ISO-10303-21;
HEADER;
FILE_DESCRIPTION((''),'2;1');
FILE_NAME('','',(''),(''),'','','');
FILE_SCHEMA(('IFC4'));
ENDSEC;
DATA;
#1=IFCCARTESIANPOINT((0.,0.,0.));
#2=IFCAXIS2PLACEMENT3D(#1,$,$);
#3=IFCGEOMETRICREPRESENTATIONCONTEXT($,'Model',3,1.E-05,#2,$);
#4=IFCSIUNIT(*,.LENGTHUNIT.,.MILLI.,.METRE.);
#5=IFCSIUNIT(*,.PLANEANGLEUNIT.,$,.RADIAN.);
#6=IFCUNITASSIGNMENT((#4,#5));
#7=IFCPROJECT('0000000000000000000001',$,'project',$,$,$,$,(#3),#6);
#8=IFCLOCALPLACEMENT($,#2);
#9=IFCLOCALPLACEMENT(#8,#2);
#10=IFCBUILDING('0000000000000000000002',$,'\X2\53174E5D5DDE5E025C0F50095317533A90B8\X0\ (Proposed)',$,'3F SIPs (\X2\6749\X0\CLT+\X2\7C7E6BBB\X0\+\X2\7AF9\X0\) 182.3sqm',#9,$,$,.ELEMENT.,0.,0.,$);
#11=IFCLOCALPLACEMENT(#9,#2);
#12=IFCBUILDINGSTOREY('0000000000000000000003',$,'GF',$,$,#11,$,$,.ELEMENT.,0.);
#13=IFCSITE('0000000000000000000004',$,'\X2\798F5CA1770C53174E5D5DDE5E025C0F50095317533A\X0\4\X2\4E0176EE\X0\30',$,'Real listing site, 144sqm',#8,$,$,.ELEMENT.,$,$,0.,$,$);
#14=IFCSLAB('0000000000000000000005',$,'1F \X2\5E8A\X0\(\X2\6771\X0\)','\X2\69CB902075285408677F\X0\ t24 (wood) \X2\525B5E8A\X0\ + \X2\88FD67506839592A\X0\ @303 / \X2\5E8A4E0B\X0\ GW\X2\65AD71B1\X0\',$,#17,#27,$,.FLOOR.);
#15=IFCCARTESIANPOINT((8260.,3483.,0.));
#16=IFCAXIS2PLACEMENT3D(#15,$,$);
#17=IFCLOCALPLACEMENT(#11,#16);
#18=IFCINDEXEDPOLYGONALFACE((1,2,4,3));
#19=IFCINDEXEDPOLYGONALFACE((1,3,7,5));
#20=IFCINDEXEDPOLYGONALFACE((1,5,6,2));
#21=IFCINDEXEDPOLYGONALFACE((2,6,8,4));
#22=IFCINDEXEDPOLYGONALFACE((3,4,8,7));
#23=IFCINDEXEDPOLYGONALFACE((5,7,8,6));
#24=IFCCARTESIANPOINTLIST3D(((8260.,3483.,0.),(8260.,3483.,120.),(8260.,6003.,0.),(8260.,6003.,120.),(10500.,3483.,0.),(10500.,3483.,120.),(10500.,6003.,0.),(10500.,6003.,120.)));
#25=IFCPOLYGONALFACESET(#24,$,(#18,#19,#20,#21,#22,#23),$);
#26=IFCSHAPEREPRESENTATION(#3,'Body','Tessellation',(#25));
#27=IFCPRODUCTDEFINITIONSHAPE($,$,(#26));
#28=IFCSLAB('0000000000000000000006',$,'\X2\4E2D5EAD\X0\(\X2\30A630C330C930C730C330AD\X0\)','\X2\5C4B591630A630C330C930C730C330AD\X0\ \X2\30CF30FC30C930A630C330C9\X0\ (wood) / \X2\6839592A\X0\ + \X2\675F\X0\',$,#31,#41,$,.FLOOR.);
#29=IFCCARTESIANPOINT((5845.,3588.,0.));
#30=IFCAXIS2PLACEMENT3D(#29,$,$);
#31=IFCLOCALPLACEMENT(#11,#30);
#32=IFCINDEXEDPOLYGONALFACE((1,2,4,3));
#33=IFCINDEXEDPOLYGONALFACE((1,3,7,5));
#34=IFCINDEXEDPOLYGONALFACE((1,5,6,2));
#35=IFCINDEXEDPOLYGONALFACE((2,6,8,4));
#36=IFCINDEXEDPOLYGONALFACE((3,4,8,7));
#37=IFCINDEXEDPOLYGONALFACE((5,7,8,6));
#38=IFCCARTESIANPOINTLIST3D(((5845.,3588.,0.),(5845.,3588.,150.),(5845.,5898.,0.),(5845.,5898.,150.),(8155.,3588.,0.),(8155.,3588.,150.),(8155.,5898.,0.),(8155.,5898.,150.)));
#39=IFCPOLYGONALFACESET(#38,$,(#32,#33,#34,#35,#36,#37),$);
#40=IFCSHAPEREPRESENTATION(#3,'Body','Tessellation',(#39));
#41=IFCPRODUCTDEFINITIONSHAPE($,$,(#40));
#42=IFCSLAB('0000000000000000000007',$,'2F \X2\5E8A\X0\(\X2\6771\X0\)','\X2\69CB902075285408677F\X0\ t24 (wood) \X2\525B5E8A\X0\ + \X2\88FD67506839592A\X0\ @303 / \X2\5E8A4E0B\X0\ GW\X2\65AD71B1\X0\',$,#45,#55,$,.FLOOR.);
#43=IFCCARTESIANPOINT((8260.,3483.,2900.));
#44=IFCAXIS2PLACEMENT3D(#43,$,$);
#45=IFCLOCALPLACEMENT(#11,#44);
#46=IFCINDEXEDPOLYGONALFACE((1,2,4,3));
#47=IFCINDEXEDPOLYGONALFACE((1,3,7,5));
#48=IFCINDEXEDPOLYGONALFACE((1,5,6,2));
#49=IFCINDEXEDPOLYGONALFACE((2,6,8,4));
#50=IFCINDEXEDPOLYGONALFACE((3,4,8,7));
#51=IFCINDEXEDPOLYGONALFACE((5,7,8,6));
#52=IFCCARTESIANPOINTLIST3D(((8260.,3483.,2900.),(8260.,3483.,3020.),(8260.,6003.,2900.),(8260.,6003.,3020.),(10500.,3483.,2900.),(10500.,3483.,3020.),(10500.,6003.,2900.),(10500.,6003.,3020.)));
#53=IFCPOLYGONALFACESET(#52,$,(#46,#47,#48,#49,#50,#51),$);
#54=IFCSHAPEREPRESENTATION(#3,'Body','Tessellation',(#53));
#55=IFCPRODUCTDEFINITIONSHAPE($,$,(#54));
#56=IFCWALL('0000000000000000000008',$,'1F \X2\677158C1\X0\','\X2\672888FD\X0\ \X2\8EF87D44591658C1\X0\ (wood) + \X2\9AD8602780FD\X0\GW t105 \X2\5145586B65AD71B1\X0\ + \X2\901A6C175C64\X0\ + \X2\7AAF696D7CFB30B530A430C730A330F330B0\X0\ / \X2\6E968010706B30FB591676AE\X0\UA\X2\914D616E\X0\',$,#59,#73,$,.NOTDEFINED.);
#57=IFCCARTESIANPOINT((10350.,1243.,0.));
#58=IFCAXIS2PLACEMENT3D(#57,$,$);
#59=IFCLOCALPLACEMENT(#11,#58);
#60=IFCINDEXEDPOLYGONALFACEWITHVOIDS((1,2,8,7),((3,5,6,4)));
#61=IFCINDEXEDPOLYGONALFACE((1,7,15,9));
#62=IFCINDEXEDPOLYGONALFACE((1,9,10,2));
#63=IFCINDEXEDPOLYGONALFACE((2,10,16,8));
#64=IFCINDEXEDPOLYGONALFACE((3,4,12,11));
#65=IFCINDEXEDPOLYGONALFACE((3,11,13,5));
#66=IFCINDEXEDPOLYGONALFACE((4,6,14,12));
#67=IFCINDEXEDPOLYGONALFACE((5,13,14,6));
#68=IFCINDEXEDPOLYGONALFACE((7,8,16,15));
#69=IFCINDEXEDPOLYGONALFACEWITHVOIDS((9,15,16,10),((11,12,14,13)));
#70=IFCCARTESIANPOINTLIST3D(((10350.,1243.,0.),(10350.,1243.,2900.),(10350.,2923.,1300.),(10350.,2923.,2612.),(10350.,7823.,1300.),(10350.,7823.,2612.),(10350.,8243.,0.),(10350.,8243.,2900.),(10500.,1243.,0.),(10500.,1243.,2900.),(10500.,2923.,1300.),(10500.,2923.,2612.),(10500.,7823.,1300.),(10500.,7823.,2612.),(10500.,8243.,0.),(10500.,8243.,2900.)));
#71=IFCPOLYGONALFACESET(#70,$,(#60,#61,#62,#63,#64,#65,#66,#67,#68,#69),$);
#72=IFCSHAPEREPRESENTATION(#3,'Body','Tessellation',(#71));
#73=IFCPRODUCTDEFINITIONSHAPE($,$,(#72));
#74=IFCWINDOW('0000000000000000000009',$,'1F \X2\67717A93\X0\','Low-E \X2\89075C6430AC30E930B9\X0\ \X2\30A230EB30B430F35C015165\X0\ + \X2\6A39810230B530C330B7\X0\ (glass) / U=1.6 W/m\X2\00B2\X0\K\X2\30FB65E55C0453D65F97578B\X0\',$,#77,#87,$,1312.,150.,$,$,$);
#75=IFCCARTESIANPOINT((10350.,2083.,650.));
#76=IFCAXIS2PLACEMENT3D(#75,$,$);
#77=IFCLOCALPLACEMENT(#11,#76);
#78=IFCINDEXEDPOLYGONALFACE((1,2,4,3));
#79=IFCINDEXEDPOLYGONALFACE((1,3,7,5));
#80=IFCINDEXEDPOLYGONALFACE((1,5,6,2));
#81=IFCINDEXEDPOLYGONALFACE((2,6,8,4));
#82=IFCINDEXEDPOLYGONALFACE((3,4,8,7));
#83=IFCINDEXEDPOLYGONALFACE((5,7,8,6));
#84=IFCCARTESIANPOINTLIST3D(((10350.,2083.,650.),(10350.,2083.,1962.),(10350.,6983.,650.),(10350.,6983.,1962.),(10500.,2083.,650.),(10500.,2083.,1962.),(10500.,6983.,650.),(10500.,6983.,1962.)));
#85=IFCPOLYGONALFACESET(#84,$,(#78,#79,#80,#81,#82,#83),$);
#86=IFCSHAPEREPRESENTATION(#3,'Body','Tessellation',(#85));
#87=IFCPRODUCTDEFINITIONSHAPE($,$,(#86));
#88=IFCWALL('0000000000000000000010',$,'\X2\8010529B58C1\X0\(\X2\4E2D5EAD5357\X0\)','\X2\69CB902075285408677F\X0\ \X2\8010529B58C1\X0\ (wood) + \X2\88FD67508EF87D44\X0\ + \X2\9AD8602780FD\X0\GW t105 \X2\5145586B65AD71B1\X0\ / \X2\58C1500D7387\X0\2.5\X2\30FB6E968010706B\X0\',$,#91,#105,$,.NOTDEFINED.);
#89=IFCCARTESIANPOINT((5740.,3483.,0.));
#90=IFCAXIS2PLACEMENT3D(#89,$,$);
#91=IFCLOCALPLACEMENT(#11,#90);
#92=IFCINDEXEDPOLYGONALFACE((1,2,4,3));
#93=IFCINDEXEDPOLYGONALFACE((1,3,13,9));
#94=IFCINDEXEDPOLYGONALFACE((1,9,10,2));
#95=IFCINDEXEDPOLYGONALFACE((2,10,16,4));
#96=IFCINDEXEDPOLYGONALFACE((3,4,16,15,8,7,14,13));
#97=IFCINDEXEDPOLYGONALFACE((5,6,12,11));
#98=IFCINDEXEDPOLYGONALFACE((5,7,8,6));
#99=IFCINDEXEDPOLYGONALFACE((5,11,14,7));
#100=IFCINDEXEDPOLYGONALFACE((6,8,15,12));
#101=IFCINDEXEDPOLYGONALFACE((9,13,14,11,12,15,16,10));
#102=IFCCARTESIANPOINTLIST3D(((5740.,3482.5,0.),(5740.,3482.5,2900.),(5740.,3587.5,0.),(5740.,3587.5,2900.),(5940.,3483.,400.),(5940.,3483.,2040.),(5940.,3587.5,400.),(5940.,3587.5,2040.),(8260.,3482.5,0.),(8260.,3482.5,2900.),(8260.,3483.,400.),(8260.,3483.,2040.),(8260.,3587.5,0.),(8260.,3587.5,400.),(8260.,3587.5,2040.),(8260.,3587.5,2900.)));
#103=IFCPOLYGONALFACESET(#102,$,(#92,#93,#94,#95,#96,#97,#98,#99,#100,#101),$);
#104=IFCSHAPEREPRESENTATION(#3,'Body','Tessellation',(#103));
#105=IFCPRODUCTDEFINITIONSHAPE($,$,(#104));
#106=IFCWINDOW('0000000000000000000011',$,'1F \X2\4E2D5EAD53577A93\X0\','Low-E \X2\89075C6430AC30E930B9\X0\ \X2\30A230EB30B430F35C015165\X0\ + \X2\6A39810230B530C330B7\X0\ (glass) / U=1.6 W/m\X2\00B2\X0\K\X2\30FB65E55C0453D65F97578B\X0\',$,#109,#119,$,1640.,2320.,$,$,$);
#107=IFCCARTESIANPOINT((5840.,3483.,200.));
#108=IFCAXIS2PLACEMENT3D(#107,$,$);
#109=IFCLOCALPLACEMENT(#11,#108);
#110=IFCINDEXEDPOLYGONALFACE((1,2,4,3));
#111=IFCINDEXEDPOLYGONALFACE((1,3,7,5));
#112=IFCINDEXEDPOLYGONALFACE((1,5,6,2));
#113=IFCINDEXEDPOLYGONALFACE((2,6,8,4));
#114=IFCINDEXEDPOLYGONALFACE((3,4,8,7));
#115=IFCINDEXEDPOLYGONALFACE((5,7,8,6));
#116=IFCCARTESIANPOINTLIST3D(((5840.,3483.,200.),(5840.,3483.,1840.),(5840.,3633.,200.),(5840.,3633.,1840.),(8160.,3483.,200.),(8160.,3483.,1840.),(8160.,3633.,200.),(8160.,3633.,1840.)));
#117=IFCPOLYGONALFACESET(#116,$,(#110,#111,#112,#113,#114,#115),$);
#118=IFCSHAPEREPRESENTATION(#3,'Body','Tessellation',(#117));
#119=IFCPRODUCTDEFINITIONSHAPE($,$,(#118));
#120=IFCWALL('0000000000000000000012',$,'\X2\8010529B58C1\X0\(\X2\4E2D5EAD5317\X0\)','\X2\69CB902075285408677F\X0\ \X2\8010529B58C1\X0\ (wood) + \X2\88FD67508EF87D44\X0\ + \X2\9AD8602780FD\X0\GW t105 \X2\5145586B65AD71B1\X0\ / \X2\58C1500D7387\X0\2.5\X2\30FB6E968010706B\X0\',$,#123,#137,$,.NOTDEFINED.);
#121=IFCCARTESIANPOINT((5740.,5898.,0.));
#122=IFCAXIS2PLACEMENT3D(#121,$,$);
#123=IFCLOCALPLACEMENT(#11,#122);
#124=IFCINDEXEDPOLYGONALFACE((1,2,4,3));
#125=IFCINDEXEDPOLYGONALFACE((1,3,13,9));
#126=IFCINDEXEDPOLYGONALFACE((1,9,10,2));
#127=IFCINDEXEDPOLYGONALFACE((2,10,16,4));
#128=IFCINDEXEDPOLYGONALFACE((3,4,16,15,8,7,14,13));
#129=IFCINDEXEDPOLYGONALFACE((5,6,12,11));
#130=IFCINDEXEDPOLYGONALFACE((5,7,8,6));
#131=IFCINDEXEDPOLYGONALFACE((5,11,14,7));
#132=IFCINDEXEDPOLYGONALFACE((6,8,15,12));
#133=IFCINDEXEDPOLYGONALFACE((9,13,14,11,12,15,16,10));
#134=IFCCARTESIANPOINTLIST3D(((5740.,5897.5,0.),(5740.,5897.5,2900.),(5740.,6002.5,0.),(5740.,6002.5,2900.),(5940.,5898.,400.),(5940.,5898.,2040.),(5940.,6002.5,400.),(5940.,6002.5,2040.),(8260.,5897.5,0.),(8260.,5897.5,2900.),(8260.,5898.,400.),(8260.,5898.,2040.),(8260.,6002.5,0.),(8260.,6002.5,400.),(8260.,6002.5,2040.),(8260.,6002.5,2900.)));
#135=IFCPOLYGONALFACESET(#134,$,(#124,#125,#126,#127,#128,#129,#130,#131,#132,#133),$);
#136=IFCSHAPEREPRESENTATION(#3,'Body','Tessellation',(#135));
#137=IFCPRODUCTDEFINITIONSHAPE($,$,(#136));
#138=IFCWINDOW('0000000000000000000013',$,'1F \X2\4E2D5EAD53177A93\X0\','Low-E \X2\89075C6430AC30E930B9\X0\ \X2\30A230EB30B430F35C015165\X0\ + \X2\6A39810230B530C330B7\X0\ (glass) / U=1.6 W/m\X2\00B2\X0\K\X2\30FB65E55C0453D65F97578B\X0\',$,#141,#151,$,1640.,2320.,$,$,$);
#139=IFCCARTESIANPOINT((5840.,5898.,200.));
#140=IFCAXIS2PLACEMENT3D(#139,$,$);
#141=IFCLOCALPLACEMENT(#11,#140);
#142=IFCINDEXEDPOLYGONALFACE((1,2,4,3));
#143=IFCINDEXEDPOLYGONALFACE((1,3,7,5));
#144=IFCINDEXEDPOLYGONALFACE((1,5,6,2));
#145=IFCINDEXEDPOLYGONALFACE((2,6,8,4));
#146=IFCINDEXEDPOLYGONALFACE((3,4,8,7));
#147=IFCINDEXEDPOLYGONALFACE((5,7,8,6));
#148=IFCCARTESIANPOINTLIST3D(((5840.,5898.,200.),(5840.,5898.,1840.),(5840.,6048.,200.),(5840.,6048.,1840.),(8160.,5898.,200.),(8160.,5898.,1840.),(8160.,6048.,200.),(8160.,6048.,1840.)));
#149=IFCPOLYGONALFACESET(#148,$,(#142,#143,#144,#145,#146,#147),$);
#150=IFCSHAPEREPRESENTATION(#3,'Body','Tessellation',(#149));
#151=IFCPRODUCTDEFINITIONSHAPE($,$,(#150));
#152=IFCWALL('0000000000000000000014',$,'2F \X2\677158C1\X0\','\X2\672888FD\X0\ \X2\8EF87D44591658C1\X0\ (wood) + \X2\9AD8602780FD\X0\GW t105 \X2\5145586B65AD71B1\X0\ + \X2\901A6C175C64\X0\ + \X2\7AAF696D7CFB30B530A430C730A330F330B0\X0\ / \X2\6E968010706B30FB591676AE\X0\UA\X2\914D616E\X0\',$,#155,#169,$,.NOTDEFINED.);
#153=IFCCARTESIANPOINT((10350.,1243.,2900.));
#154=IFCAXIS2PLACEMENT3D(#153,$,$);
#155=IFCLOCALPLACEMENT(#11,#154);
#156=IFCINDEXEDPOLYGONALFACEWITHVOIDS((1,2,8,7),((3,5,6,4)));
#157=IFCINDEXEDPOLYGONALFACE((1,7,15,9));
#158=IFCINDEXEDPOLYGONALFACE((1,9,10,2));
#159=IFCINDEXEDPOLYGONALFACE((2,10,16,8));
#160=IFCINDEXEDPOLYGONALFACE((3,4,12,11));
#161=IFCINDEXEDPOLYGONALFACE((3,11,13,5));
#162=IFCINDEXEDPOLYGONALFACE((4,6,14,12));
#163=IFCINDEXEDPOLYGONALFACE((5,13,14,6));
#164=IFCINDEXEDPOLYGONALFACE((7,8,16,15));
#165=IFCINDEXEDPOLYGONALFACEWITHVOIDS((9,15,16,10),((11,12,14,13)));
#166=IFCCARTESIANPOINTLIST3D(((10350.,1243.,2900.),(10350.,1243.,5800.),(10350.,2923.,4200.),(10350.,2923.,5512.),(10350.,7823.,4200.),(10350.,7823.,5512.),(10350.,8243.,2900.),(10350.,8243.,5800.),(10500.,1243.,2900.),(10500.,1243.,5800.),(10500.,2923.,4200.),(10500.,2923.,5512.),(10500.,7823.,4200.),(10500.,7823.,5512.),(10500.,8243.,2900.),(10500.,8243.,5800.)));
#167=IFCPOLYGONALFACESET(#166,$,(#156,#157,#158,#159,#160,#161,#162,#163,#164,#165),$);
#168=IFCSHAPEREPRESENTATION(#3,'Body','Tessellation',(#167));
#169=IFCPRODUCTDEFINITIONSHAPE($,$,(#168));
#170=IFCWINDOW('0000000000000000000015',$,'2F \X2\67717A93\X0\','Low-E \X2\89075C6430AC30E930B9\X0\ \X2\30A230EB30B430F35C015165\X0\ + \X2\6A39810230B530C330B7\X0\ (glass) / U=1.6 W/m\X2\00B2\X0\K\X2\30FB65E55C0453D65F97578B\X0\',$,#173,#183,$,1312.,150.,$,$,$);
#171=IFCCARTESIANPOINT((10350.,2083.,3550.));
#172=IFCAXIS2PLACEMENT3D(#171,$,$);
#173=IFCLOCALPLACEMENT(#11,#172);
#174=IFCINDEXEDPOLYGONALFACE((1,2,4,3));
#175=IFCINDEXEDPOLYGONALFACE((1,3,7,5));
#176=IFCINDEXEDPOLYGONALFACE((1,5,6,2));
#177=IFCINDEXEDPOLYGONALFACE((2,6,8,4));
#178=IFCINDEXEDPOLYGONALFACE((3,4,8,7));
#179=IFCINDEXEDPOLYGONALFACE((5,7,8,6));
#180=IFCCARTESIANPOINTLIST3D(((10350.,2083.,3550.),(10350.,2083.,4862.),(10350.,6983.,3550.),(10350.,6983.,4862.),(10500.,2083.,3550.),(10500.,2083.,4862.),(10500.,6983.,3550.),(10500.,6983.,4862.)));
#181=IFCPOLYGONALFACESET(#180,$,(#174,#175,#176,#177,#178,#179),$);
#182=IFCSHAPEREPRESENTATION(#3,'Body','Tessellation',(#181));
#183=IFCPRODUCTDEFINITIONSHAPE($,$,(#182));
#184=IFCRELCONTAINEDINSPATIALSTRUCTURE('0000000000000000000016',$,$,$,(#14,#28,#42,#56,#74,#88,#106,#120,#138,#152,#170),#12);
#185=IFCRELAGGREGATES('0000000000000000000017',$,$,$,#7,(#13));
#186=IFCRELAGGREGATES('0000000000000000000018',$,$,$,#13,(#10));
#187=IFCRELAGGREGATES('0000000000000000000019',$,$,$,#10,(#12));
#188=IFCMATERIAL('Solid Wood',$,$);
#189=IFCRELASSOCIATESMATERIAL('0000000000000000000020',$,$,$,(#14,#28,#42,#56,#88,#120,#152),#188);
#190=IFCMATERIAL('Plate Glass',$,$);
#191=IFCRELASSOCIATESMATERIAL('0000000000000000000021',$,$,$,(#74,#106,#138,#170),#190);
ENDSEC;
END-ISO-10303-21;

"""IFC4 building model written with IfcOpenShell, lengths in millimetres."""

from ifc_helpers import new_model, si_unit, frame, frame_2d, origin, place, context, project, spatial, rectangle, extrude, material, element, fill, save


model = new_model("IFC4")

# Units and contexts
model_context = context("Model", 3, precision=1e-05, world=origin())
ifc_project = project(units=[si_unit("LENGTHUNIT", "METRE", prefix="MILLI"), si_unit("PLANEANGLEUNIT", "RADIAN")], contexts=[model_context])

# Site, building, storey
site_placement = place(None, origin())
site = spatial("IfcSite", under=ifc_project, at=site_placement, Name="福岡県北九州市小倉北区4丁目30", ObjectType="Real listing site, 144sqm", CompositionType="ELEMENT", RefElevation=0.0)
building_placement = place(site_placement, origin())
building = spatial("IfcBuilding", under=site, at=building_placement, Name="北九州市小倉北区邸 (Proposed)", ObjectType="3F SIPs (杉CLT+籾殻+竹) 182.3sqm", CompositionType="ELEMENT", ElevationOfRefHeight=0.0, ElevationOfTerrain=0.0)
storey_placement = place(building_placement, origin())
storey = spatial("IfcBuildingStorey", under=building, at=storey_placement, Name="GF", CompositionType="ELEMENT", Elevation=0.0)

# Slabs
ifc_material_1 = material(Name="Solid Wood")
slab_1_placement = place(storey_placement, frame((8260.0, 3483.0, 0.0)))
element("IfcSlab", 1, at=slab_1_placement, inside=storey, material=ifc_material_1, Name="1F 床(東)", Description="構造用合板 t24 (wood) 剛床 + 製材根太 @303 / 床下 GW断熱", PredefinedType="FLOOR", context=model_context, shape_type="SweptSolid", body=[
    extrude(rectangle(XDim=2240.0, YDim=2520.0, at=frame_2d((1120.0, 1260.0))), frame((8260.0, 3483.0, 0.0)), (0.0, 0.0, 1.0), 120.0),
])
slab_2_placement = place(storey_placement, frame((5845.0, 3588.0, 0.0)))
element("IfcSlab", 2, at=slab_2_placement, inside=storey, material=ifc_material_1, Name="中庭(ウッドデッキ)", Description="屋外ウッドデッキ ハードウッド (wood) / 根太 + 束", PredefinedType="FLOOR", context=model_context, shape_type="SweptSolid", body=[
    extrude(rectangle(XDim=2310.0, YDim=2310.0, at=frame_2d((1155.0, 1155.0))), frame((5845.0, 3588.0, 0.0)), (0.0, 0.0, 1.0), 150.0),
])
slab_3_placement = place(storey_placement, frame((8260.0, 3483.0, 2900.0)))
element("IfcSlab", 3, at=slab_3_placement, inside=storey, material=ifc_material_1, Name="2F 床(東)", Description="構造用合板 t24 (wood) 剛床 + 製材根太 @303 / 床下 GW断熱", PredefinedType="FLOOR", context=model_context, shape_type="SweptSolid", body=[
    extrude(rectangle(XDim=2240.0, YDim=2520.0, at=frame_2d((1120.0, 1260.0))), frame((8260.0, 3483.0, 2900.0)), (0.0, 0.0, 1.0), 120.0),
])

# Walls, openings, windows
wall_1_placement = place(storey_placement, frame((10350.0, 1243.0, 0.0)))
wall_1 = element("IfcWall", 4, at=wall_1_placement, inside=storey, material=ifc_material_1, Name="1F 東壁", Description="木製 軸組外壁 (wood) + 高性能GW t105 充填断熱 + 通気層 + 窯業系サイディング / 準耐火・外皮UA配慮", PredefinedType="NOTDEFINED", context=model_context, shape_type="SweptSolid", body=[
    extrude(rectangle(XDim=150.0, YDim=7000.0, at=frame_2d((75.0, 3500.0))), frame((10350.0, 1243.0, 0.0)), (0.0, 0.0, 1.0), 2900.0),
])
opening_1_placement = place(storey_placement, frame((10350.0, 2083.0, 650.0)))
opening_1 = element("IfcOpeningElement", 5, at=opening_1_placement, cuts=wall_1, PredefinedType="NOTDEFINED", context=model_context, shape_type="SweptSolid", body=[
    extrude(rectangle(XDim=150.0, YDim=4900.0, at=frame_2d((75.0, 2450.0))), frame((10350.0, 2083.0, 650.0)), (0.0, 0.0, 1.0), 1312.0),
])
ifc_material_2 = material(Name="Plate Glass")
window_1_placement = place(storey_placement, frame((10350.0, 2083.0, 650.0)))
window_1 = element("IfcWindow", 6, at=window_1_placement, inside=storey, material=ifc_material_2, Name="1F 東窓", Description="Low-E 複層ガラス アルゴン封入 + 樹脂サッシ (glass) / U=1.6 W/m²K・日射取得型", OverallHeight=1312.0, OverallWidth=150.0, context=model_context, shape_type="SweptSolid", body=[
    extrude(rectangle(XDim=150.0, YDim=4900.0, at=frame_2d((75.0, 2450.0))), frame((10350.0, 2083.0, 650.0)), (0.0, 0.0, 1.0), 1312.0),
])
fill(opening_1, window_1)
wall_2_placement = place(storey_placement, frame((5740.0, 3483.0, 0.0)))
wall_2 = element("IfcWall", 7, at=wall_2_placement, inside=storey, material=ifc_material_1, Name="耐力壁(中庭南)", Description="構造用合板 耐力壁 (wood) + 製材軸組 + 高性能GW t105 充填断熱 / 壁倍率2.5・準耐火", PredefinedType="NOTDEFINED", context=model_context, shape_type="SweptSolid", body=[
    extrude(rectangle(XDim=2520.0, YDim=105.0, at=frame_2d((1260.0, 52.0))), frame((5740.0, 3483.0, 0.0)), (0.0, 0.0, 1.0), 2900.0),
])
opening_2_placement = place(storey_placement, frame((5840.0, 3483.0, 200.0)))
opening_2 = element("IfcOpeningElement", 8, at=opening_2_placement, cuts=wall_2, PredefinedType="NOTDEFINED", context=model_context, shape_type="SweptSolid", body=[
    extrude(rectangle(XDim=2320.0, YDim=150.0, at=frame_2d((1160.0, 75.0))), frame((5840.0, 3483.0, 200.0)), (0.0, 0.0, 1.0), 1640.0),
])
window_2_placement = place(storey_placement, frame((5840.0, 3483.0, 200.0)))
window_2 = element("IfcWindow", 9, at=window_2_placement, inside=storey, material=ifc_material_2, Name="1F 中庭南窓", Description="Low-E 複層ガラス アルゴン封入 + 樹脂サッシ (glass) / U=1.6 W/m²K・日射取得型", OverallHeight=1640.0, OverallWidth=2320.0, context=model_context, shape_type="SweptSolid", body=[
    extrude(rectangle(XDim=2320.0, YDim=150.0, at=frame_2d((1160.0, 75.0))), frame((5840.0, 3483.0, 200.0)), (0.0, 0.0, 1.0), 1640.0),
])
fill(opening_2, window_2)
wall_3_placement = place(storey_placement, frame((5740.0, 5898.0, 0.0)))
wall_3 = element("IfcWall", 10, at=wall_3_placement, inside=storey, material=ifc_material_1, Name="耐力壁(中庭北)", Description="構造用合板 耐力壁 (wood) + 製材軸組 + 高性能GW t105 充填断熱 / 壁倍率2.5・準耐火", PredefinedType="NOTDEFINED", context=model_context, shape_type="SweptSolid", body=[
    extrude(rectangle(XDim=2520.0, YDim=105.0, at=frame_2d((1260.0, 52.0))), frame((5740.0, 5898.0, 0.0)), (0.0, 0.0, 1.0), 2900.0),
])
opening_3_placement = place(storey_placement, frame((5840.0, 5898.0, 200.0)))
opening_3 = element("IfcOpeningElement", 11, at=opening_3_placement, cuts=wall_3, PredefinedType="NOTDEFINED", context=model_context, shape_type="SweptSolid", body=[
    extrude(rectangle(XDim=2320.0, YDim=150.0, at=frame_2d((1160.0, 75.0))), frame((5840.0, 5898.0, 200.0)), (0.0, 0.0, 1.0), 1640.0),
])
window_3_placement = place(storey_placement, frame((5840.0, 5898.0, 200.0)))
window_3 = element("IfcWindow", 12, at=window_3_placement, inside=storey, material=ifc_material_2, Name="1F 中庭北窓", Description="Low-E 複層ガラス アルゴン封入 + 樹脂サッシ (glass) / U=1.6 W/m²K・日射取得型", OverallHeight=1640.0, OverallWidth=2320.0, context=model_context, shape_type="SweptSolid", body=[
    extrude(rectangle(XDim=2320.0, YDim=150.0, at=frame_2d((1160.0, 75.0))), frame((5840.0, 5898.0, 200.0)), (0.0, 0.0, 1.0), 1640.0),
])
fill(opening_3, window_3)

# Wall, opening, window
wall_4_placement = place(storey_placement, frame((10350.0, 1243.0, 2900.0)))
wall_4 = element("IfcWall", 13, at=wall_4_placement, inside=storey, material=ifc_material_1, Name="2F 東壁", Description="木製 軸組外壁 (wood) + 高性能GW t105 充填断熱 + 通気層 + 窯業系サイディング / 準耐火・外皮UA配慮", PredefinedType="NOTDEFINED", context=model_context, shape_type="SweptSolid", body=[
    extrude(rectangle(XDim=150.0, YDim=7000.0, at=frame_2d((75.0, 3500.0))), frame((10350.0, 1243.0, 2900.0)), (0.0, 0.0, 1.0), 2900.0),
])
opening_4_placement = place(storey_placement, frame((10350.0, 2083.0, 3550.0)))
opening_4 = element("IfcOpeningElement", 14, at=opening_4_placement, cuts=wall_4, PredefinedType="NOTDEFINED", context=model_context, shape_type="SweptSolid", body=[
    extrude(rectangle(XDim=150.0, YDim=4900.0, at=frame_2d((75.0, 2450.0))), frame((10350.0, 2083.0, 3550.0)), (0.0, 0.0, 1.0), 1312.0),
])
window_4_placement = place(storey_placement, frame((10350.0, 2083.0, 3550.0)))
window_4 = element("IfcWindow", 15, at=window_4_placement, inside=storey, material=ifc_material_2, Name="2F 東窓", Description="Low-E 複層ガラス アルゴン封入 + 樹脂サッシ (glass) / U=1.6 W/m²K・日射取得型", OverallHeight=1312.0, OverallWidth=150.0, context=model_context, shape_type="SweptSolid", body=[
    extrude(rectangle(XDim=150.0, YDim=4900.0, at=frame_2d((75.0, 2450.0))), frame((10350.0, 2083.0, 3550.0)), (0.0, 0.0, 1.0), 1312.0),
])
fill(opening_4, window_4)

save(model, "model.ifc")
